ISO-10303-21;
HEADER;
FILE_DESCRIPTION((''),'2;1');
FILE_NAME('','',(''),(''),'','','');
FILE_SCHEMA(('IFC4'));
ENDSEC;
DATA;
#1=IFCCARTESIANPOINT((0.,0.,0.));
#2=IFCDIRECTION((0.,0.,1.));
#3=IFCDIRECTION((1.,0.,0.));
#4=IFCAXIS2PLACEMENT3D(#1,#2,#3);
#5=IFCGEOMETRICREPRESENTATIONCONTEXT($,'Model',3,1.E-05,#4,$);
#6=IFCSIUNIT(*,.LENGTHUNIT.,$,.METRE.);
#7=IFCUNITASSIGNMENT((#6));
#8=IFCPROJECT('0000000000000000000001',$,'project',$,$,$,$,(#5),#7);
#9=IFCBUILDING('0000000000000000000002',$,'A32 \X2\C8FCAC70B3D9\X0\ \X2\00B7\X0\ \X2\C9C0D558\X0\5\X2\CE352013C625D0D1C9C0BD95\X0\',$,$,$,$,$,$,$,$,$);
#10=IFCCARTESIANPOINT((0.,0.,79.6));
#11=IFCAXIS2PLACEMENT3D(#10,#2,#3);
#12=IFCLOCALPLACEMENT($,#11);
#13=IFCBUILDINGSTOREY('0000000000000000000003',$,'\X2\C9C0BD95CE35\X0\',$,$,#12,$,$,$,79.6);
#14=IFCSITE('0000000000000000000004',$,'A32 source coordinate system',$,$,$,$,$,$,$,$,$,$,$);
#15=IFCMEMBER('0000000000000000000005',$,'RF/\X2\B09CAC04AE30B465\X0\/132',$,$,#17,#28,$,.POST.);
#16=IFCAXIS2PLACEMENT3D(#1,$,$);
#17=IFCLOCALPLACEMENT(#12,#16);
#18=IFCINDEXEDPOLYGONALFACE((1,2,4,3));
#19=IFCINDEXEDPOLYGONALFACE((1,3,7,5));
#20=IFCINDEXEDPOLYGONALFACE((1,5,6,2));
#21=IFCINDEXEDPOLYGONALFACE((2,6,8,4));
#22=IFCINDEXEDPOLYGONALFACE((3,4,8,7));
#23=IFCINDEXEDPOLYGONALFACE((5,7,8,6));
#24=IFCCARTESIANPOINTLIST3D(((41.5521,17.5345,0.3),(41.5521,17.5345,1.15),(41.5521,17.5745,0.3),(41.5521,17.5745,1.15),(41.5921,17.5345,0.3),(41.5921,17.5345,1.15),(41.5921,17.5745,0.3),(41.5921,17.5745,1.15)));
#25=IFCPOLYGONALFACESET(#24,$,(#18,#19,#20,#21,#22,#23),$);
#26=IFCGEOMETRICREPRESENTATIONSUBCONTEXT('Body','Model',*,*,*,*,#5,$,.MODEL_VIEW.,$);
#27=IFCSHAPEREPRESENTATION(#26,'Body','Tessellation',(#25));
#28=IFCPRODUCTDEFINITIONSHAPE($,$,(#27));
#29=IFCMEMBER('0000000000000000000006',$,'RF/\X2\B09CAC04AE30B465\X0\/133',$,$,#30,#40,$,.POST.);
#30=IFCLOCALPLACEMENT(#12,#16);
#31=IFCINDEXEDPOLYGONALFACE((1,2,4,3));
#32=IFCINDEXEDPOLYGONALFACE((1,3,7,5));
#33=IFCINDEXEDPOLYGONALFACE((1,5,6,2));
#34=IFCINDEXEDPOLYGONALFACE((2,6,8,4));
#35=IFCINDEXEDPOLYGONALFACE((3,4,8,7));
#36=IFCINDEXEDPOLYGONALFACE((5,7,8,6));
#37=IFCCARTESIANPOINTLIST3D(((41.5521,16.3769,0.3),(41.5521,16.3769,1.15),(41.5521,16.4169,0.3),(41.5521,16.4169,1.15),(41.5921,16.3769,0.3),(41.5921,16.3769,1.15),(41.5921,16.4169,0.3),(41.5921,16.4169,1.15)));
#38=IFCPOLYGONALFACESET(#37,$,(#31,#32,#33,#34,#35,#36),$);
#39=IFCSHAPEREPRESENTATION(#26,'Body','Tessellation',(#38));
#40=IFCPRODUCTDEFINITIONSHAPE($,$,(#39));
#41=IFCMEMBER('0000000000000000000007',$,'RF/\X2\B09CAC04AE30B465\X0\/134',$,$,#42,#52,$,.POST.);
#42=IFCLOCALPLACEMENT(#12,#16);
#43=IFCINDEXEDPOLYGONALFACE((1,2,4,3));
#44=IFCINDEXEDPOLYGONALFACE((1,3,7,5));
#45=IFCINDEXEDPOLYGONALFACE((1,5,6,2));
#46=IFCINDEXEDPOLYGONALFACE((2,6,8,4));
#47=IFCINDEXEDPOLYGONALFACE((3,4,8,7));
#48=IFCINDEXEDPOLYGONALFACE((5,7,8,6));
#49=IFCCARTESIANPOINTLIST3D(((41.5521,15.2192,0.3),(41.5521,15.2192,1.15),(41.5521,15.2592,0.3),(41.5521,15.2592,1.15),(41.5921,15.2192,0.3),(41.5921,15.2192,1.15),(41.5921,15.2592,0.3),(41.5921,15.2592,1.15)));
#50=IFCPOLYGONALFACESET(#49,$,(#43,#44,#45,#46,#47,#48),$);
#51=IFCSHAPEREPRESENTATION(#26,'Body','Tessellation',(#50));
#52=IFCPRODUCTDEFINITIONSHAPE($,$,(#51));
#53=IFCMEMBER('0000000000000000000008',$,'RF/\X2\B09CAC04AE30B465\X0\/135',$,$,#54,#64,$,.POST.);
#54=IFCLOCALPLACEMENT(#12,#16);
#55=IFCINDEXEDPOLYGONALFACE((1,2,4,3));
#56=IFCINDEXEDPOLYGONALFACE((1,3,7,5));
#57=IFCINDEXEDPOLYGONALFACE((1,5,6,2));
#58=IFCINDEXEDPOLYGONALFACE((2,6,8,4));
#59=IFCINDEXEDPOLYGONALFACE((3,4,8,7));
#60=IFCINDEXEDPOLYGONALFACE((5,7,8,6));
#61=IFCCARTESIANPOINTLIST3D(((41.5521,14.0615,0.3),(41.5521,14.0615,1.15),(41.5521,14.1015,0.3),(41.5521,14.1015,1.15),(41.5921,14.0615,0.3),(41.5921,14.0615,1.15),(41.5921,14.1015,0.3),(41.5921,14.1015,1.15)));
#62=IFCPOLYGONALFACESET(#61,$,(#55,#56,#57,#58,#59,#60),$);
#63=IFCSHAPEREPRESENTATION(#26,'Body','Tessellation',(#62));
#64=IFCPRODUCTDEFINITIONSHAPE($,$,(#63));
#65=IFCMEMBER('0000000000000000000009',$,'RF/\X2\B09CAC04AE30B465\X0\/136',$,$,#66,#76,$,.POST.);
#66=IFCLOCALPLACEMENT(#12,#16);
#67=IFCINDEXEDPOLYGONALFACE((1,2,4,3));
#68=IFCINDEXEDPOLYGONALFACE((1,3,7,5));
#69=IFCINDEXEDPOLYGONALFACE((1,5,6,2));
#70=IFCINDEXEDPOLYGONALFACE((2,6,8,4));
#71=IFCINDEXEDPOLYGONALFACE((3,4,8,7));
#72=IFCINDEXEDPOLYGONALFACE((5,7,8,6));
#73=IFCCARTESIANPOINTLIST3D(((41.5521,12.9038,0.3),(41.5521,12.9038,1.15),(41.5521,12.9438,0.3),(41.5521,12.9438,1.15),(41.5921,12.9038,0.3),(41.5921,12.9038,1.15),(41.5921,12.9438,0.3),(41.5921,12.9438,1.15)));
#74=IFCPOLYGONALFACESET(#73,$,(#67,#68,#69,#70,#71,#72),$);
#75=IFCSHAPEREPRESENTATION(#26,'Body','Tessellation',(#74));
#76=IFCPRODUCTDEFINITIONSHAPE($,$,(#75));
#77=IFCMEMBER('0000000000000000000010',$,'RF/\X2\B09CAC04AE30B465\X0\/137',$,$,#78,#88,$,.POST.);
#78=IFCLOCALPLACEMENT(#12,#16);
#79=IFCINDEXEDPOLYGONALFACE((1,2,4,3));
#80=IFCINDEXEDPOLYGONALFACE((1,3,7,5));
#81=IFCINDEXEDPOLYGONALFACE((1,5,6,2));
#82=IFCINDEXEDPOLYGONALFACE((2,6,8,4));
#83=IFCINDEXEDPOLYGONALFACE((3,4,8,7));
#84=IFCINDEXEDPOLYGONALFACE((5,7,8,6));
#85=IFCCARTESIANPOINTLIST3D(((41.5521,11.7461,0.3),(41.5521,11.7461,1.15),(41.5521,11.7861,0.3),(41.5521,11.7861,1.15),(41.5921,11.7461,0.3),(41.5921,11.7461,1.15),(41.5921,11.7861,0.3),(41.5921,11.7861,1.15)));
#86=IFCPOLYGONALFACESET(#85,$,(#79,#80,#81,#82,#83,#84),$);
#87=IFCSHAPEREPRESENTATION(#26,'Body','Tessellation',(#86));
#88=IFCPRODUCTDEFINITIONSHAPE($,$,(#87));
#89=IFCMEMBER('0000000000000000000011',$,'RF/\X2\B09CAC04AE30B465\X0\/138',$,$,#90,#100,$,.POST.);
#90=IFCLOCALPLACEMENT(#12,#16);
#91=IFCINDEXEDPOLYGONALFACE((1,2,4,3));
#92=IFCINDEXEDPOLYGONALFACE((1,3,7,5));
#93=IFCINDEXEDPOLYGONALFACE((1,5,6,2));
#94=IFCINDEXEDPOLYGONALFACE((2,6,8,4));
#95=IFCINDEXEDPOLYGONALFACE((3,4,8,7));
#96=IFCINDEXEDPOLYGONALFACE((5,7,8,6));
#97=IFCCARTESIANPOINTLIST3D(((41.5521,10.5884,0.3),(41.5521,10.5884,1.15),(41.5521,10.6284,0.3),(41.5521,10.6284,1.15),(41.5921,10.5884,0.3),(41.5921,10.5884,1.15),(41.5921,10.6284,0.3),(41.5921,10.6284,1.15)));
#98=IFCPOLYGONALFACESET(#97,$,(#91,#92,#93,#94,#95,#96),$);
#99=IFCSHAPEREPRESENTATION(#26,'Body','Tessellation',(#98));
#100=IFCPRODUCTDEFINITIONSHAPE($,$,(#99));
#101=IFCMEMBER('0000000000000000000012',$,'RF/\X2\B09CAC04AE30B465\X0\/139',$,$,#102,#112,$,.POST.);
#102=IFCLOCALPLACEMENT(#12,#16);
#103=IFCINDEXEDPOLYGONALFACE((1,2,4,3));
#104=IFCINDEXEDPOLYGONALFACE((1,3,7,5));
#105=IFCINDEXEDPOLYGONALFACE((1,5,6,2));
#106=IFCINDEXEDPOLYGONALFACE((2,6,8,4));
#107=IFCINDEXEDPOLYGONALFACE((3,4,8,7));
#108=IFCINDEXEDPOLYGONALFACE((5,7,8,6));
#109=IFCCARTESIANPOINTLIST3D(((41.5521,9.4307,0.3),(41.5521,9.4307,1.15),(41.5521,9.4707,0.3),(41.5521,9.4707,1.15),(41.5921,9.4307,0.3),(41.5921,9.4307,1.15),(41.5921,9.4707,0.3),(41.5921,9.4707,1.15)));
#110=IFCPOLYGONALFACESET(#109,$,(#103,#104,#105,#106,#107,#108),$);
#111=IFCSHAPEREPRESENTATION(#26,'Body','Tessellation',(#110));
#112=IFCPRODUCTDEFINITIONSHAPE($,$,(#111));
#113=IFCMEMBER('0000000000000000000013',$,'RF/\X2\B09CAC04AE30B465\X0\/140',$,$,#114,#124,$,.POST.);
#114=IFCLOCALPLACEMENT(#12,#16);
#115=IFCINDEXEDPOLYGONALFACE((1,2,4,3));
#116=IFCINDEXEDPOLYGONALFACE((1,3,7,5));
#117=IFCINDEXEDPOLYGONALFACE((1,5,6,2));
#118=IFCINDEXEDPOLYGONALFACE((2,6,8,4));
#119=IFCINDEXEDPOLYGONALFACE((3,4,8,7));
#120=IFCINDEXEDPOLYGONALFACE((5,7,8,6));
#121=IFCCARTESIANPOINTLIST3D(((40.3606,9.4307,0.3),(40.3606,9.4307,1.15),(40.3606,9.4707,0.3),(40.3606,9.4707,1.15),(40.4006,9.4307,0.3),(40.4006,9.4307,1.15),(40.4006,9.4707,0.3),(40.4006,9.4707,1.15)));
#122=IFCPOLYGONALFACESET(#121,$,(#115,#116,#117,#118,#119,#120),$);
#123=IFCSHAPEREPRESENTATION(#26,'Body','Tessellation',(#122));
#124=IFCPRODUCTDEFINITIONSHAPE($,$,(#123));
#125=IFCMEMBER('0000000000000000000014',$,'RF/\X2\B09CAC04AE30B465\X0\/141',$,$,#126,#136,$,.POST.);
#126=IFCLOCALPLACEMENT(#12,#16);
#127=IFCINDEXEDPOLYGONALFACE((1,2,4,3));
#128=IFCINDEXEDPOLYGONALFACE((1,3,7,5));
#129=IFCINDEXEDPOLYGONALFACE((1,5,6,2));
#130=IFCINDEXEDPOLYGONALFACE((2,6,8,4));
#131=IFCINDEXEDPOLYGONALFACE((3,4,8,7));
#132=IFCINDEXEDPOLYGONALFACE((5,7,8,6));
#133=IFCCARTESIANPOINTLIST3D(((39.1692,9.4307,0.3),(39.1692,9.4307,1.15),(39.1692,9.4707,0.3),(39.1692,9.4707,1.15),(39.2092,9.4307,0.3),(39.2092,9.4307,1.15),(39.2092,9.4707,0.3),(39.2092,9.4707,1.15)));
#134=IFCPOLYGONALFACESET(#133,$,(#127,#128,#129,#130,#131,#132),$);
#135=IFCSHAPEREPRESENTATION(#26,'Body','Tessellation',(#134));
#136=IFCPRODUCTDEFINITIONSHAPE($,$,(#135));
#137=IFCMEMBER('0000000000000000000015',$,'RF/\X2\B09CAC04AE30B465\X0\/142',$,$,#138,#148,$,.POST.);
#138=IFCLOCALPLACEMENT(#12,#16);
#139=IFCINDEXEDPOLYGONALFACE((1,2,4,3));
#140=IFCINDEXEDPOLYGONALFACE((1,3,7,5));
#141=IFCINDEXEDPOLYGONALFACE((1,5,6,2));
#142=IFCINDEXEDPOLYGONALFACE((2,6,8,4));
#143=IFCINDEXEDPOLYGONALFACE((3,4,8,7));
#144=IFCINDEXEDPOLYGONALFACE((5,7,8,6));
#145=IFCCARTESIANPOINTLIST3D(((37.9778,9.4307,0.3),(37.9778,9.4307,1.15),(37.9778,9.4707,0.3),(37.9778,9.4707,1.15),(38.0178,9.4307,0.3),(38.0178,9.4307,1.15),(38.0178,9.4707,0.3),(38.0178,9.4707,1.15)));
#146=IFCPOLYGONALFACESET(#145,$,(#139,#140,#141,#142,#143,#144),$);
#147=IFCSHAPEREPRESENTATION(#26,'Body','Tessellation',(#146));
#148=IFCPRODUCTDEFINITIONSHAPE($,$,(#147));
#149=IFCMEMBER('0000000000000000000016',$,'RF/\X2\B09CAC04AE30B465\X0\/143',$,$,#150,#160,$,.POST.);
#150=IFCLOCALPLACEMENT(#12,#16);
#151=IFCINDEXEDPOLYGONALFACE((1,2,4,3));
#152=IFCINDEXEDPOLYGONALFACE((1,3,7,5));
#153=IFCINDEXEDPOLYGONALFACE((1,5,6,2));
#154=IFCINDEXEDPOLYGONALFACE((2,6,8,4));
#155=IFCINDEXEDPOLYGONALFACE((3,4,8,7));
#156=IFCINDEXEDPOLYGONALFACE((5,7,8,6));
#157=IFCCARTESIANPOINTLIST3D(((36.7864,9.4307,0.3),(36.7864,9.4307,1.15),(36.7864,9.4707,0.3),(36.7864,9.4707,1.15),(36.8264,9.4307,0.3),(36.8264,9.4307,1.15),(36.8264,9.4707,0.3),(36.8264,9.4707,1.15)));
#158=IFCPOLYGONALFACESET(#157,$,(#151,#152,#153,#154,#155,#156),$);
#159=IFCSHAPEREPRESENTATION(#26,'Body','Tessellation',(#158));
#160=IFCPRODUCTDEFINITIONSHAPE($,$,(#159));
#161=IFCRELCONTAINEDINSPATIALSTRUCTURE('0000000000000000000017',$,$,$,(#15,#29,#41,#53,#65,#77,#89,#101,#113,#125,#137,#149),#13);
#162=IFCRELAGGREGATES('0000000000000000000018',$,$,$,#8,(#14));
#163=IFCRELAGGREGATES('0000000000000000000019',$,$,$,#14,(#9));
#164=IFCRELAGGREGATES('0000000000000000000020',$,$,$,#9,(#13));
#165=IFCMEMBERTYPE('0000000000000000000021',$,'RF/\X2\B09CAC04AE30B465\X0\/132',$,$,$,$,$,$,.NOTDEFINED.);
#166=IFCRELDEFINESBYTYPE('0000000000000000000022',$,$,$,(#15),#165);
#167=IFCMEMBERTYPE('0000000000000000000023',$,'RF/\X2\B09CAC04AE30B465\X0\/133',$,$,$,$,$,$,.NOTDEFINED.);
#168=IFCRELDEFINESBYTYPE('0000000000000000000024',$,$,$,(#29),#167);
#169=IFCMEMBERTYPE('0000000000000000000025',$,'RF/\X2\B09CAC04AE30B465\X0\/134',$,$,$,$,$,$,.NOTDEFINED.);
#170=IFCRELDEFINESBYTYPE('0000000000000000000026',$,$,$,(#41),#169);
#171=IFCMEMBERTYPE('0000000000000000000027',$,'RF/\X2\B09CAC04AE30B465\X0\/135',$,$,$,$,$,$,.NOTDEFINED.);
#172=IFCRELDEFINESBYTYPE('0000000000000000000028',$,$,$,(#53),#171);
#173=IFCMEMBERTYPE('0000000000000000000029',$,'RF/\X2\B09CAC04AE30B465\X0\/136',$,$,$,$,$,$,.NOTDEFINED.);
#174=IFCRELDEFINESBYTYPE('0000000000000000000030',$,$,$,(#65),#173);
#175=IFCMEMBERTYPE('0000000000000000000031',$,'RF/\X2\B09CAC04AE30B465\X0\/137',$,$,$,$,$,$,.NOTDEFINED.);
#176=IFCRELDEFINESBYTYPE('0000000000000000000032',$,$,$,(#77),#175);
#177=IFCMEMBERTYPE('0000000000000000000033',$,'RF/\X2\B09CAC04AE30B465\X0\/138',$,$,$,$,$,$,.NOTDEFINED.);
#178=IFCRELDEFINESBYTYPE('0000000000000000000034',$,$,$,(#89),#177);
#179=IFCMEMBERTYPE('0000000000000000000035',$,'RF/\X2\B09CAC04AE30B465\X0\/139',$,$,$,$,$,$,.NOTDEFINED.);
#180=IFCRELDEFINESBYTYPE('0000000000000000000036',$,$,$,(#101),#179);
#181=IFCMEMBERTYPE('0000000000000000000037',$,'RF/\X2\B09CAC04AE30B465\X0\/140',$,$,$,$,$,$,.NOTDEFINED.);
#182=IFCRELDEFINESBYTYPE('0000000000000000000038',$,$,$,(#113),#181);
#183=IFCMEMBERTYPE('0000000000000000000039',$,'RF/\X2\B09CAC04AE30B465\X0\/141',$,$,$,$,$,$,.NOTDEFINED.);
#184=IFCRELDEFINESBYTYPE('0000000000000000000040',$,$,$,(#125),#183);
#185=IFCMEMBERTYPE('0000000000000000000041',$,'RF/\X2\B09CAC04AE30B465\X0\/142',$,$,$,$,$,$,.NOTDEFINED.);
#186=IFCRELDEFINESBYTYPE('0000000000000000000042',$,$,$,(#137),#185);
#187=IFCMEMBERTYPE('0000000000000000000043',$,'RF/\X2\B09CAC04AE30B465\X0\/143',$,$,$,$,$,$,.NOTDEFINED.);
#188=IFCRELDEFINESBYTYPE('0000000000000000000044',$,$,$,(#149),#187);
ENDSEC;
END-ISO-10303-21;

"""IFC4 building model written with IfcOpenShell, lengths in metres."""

from ifc_helpers import new_model, si_unit, frame, origin, origin_with_axes, place, context, subcontext, project, spatial, polyline, outline, extrude, source, transform, mapped, type_object, type_shapes, element, save


model = new_model("IFC4")

# Units and contexts
model_context = context("Model", 3, precision=1e-05, world=origin_with_axes())
body_context = subcontext(model_context, "Body", "Model", "MODEL_VIEW")
ifc_project = project(units=[si_unit("LENGTHUNIT", "METRE")], contexts=[model_context])

# Site, building, storey
site = spatial("IfcSite", under=ifc_project, Name="A32 source coordinate system")
building = spatial("IfcBuilding", under=site, Name="A32 주거동 · 지하5층–옥탑지붕")
storey_placement = place(None, frame((0.0, 0.0, 79.6), z_axis=(0.0, 0.0, 1.0), x_axis=(1.0, 0.0, 0.0)))
storey = spatial("IfcBuildingStorey", under=building, at=storey_placement, Name="지붕층", Elevation=79.6)

# Members
member_type_1 = type_object("IfcMemberType", Name="RF/난간기둥/132", PredefinedType="NOTDEFINED")
shared_shape_1 = source(origin(), body_context, "Body", "SweptSolid", [
    extrude(outline(polyline([(41.5921, 17.5345), (41.5521, 17.5345), (41.5521, 17.5745), (41.5921, 17.5745), (41.5921, 17.5345)])), frame((0.0, 0.0, 0.3)), (0.0, 0.0, 1.0), 0.85),
])
type_shapes(member_type_1, [shared_shape_1])
member_1_placement = place(storey_placement, origin_with_axes())
element("IfcMember", 1, at=member_1_placement, inside=storey, type_object=member_type_1, Name="RF/난간기둥/132", PredefinedType="POST", context=body_context, shape_type="MappedRepresentation", body=[
    mapped(shared_shape_1, transform((0.0, 0.0, 0.0), scale=1.0)),
])
member_type_2 = type_object("IfcMemberType", Name="RF/난간기둥/133", PredefinedType="NOTDEFINED")
shared_shape_2 = source(origin(), body_context, "Body", "SweptSolid", [
    extrude(outline(polyline([(41.5921, 16.3769), (41.5521, 16.3769), (41.5521, 16.4169), (41.5921, 16.4169), (41.5921, 16.3769)])), frame((0.0, 0.0, 0.3)), (0.0, 0.0, 1.0), 0.85),
])
type_shapes(member_type_2, [shared_shape_2])
member_2_placement = place(storey_placement, origin_with_axes())
element("IfcMember", 2, at=member_2_placement, inside=storey, type_object=member_type_2, Name="RF/난간기둥/133", PredefinedType="POST", context=body_context, shape_type="MappedRepresentation", body=[
    mapped(shared_shape_2, transform((0.0, 0.0, 0.0), scale=1.0)),
])
member_type_3 = type_object("IfcMemberType", Name="RF/난간기둥/134", PredefinedType="NOTDEFINED")
shared_shape_3 = source(origin(), body_context, "Body", "SweptSolid", [
    extrude(outline(polyline([(41.5921, 15.2192), (41.5521, 15.2192), (41.5521, 15.2592), (41.5921, 15.2592), (41.5921, 15.2192)])), frame((0.0, 0.0, 0.3)), (0.0, 0.0, 1.0), 0.85),
])
type_shapes(member_type_3, [shared_shape_3])
member_3_placement = place(storey_placement, origin_with_axes())
element("IfcMember", 3, at=member_3_placement, inside=storey, type_object=member_type_3, Name="RF/난간기둥/134", PredefinedType="POST", context=body_context, shape_type="MappedRepresentation", body=[
    mapped(shared_shape_3, transform((0.0, 0.0, 0.0), scale=1.0)),
])
member_type_4 = type_object("IfcMemberType", Name="RF/난간기둥/135", PredefinedType="NOTDEFINED")
shared_shape_4 = source(origin(), body_context, "Body", "SweptSolid", [
    extrude(outline(polyline([(41.5921, 14.0615), (41.5521, 14.0615), (41.5521, 14.1015), (41.5921, 14.1015), (41.5921, 14.0615)])), frame((0.0, 0.0, 0.3)), (0.0, 0.0, 1.0), 0.85),
])
type_shapes(member_type_4, [shared_shape_4])
member_4_placement = place(storey_placement, origin_with_axes())
element("IfcMember", 4, at=member_4_placement, inside=storey, type_object=member_type_4, Name="RF/난간기둥/135", PredefinedType="POST", context=body_context, shape_type="MappedRepresentation", body=[
    mapped(shared_shape_4, transform((0.0, 0.0, 0.0), scale=1.0)),
])
member_type_5 = type_object("IfcMemberType", Name="RF/난간기둥/136", PredefinedType="NOTDEFINED")
shared_shape_5 = source(origin(), body_context, "Body", "SweptSolid", [
    extrude(outline(polyline([(41.5921, 12.9038), (41.5521, 12.9038), (41.5521, 12.9438), (41.5921, 12.9438), (41.5921, 12.9038)])), frame((0.0, 0.0, 0.3)), (0.0, 0.0, 1.0), 0.85),
])
type_shapes(member_type_5, [shared_shape_5])
member_5_placement = place(storey_placement, origin_with_axes())
element("IfcMember", 5, at=member_5_placement, inside=storey, type_object=member_type_5, Name="RF/난간기둥/136", PredefinedType="POST", context=body_context, shape_type="MappedRepresentation", body=[
    mapped(shared_shape_5, transform((0.0, 0.0, 0.0), scale=1.0)),
])
member_type_6 = type_object("IfcMemberType", Name="RF/난간기둥/137", PredefinedType="NOTDEFINED")
shared_shape_6 = source(origin(), body_context, "Body", "SweptSolid", [
    extrude(outline(polyline([(41.5921, 11.7461), (41.5521, 11.7461), (41.5521, 11.7861), (41.5921, 11.7861), (41.5921, 11.7461)])), frame((0.0, 0.0, 0.3)), (0.0, 0.0, 1.0), 0.85),
])
type_shapes(member_type_6, [shared_shape_6])
member_6_placement = place(storey_placement, origin_with_axes())
element("IfcMember", 6, at=member_6_placement, inside=storey, type_object=member_type_6, Name="RF/난간기둥/137", PredefinedType="POST", context=body_context, shape_type="MappedRepresentation", body=[
    mapped(shared_shape_6, transform((0.0, 0.0, 0.0), scale=1.0)),
])
member_type_7 = type_object("IfcMemberType", Name="RF/난간기둥/138", PredefinedType="NOTDEFINED")
shared_shape_7 = source(origin(), body_context, "Body", "SweptSolid", [
    extrude(outline(polyline([(41.5921, 10.5884), (41.5521, 10.5884), (41.5521, 10.6284), (41.5921, 10.6284), (41.5921, 10.5884)])), frame((0.0, 0.0, 0.3)), (0.0, 0.0, 1.0), 0.85),
])
type_shapes(member_type_7, [shared_shape_7])
member_7_placement = place(storey_placement, origin_with_axes())
element("IfcMember", 7, at=member_7_placement, inside=storey, type_object=member_type_7, Name="RF/난간기둥/138", PredefinedType="POST", context=body_context, shape_type="MappedRepresentation", body=[
    mapped(shared_shape_7, transform((0.0, 0.0, 0.0), scale=1.0)),
])
member_type_8 = type_object("IfcMemberType", Name="RF/난간기둥/139", PredefinedType="NOTDEFINED")
shared_shape_8 = source(origin(), body_context, "Body", "SweptSolid", [
    extrude(outline(polyline([(41.5921, 9.4307), (41.5521, 9.4307), (41.5521, 9.4707), (41.5921, 9.4707), (41.5921, 9.4307)])), frame((0.0, 0.0, 0.3)), (0.0, 0.0, 1.0), 0.85),
])
type_shapes(member_type_8, [shared_shape_8])
member_8_placement = place(storey_placement, origin_with_axes())
element("IfcMember", 8, at=member_8_placement, inside=storey, type_object=member_type_8, Name="RF/난간기둥/139", PredefinedType="POST", context=body_context, shape_type="MappedRepresentation", body=[
    mapped(shared_shape_8, transform((0.0, 0.0, 0.0), scale=1.0)),
])
member_type_9 = type_object("IfcMemberType", Name="RF/난간기둥/140", PredefinedType="NOTDEFINED")
shared_shape_9 = source(origin(), body_context, "Body", "SweptSolid", [
    extrude(outline(polyline([(40.4006, 9.4307), (40.3606, 9.4307), (40.3606, 9.4707), (40.4006, 9.4707), (40.4006, 9.4307)])), frame((0.0, 0.0, 0.3)), (0.0, 0.0, 1.0), 0.85),
])
type_shapes(member_type_9, [shared_shape_9])
member_9_placement = place(storey_placement, origin_with_axes())
element("IfcMember", 9, at=member_9_placement, inside=storey, type_object=member_type_9, Name="RF/난간기둥/140", PredefinedType="POST", context=body_context, shape_type="MappedRepresentation", body=[
    mapped(shared_shape_9, transform((0.0, 0.0, 0.0), scale=1.0)),
])
member_type_10 = type_object("IfcMemberType", Name="RF/난간기둥/141", PredefinedType="NOTDEFINED")
shared_shape_10 = source(origin(), body_context, "Body", "SweptSolid", [
    extrude(outline(polyline([(39.2092, 9.4307), (39.1692, 9.4307), (39.1692, 9.4707), (39.2092, 9.4707), (39.2092, 9.4307)])), frame((0.0, 0.0, 0.3)), (0.0, 0.0, 1.0), 0.85),
])
type_shapes(member_type_10, [shared_shape_10])
member_10_placement = place(storey_placement, origin_with_axes())
element("IfcMember", 10, at=member_10_placement, inside=storey, type_object=member_type_10, Name="RF/난간기둥/141", PredefinedType="POST", context=body_context, shape_type="MappedRepresentation", body=[
    mapped(shared_shape_10, transform((0.0, 0.0, 0.0), scale=1.0)),
])
member_type_11 = type_object("IfcMemberType", Name="RF/난간기둥/142", PredefinedType="NOTDEFINED")
shared_shape_11 = source(origin(), body_context, "Body", "SweptSolid", [
    extrude(outline(polyline([(38.0178, 9.4307), (37.9778, 9.4307), (37.9778, 9.4707), (38.0178, 9.4707), (38.0178, 9.4307)])), frame((0.0, 0.0, 0.3)), (0.0, 0.0, 1.0), 0.85),
])
type_shapes(member_type_11, [shared_shape_11])
member_11_placement = place(storey_placement, origin_with_axes())
element("IfcMember", 11, at=member_11_placement, inside=storey, type_object=member_type_11, Name="RF/난간기둥/142", PredefinedType="POST", context=body_context, shape_type="MappedRepresentation", body=[
    mapped(shared_shape_11, transform((0.0, 0.0, 0.0), scale=1.0)),
])
member_type_12 = type_object("IfcMemberType", Name="RF/난간기둥/143", PredefinedType="NOTDEFINED")
shared_shape_12 = source(origin(), body_context, "Body", "SweptSolid", [
    extrude(outline(polyline([(36.8264, 9.4307), (36.7864, 9.4307), (36.7864, 9.4707), (36.8264, 9.4707), (36.8264, 9.4307)])), frame((0.0, 0.0, 0.3)), (0.0, 0.0, 1.0), 0.85),
])
type_shapes(member_type_12, [shared_shape_12])
member_12_placement = place(storey_placement, origin_with_axes())
element("IfcMember", 12, at=member_12_placement, inside=storey, type_object=member_type_12, Name="RF/난간기둥/143", PredefinedType="POST", context=body_context, shape_type="MappedRepresentation", body=[
    mapped(shared_shape_12, transform((0.0, 0.0, 0.0), scale=1.0)),
])

save(model, "model.ifc")
